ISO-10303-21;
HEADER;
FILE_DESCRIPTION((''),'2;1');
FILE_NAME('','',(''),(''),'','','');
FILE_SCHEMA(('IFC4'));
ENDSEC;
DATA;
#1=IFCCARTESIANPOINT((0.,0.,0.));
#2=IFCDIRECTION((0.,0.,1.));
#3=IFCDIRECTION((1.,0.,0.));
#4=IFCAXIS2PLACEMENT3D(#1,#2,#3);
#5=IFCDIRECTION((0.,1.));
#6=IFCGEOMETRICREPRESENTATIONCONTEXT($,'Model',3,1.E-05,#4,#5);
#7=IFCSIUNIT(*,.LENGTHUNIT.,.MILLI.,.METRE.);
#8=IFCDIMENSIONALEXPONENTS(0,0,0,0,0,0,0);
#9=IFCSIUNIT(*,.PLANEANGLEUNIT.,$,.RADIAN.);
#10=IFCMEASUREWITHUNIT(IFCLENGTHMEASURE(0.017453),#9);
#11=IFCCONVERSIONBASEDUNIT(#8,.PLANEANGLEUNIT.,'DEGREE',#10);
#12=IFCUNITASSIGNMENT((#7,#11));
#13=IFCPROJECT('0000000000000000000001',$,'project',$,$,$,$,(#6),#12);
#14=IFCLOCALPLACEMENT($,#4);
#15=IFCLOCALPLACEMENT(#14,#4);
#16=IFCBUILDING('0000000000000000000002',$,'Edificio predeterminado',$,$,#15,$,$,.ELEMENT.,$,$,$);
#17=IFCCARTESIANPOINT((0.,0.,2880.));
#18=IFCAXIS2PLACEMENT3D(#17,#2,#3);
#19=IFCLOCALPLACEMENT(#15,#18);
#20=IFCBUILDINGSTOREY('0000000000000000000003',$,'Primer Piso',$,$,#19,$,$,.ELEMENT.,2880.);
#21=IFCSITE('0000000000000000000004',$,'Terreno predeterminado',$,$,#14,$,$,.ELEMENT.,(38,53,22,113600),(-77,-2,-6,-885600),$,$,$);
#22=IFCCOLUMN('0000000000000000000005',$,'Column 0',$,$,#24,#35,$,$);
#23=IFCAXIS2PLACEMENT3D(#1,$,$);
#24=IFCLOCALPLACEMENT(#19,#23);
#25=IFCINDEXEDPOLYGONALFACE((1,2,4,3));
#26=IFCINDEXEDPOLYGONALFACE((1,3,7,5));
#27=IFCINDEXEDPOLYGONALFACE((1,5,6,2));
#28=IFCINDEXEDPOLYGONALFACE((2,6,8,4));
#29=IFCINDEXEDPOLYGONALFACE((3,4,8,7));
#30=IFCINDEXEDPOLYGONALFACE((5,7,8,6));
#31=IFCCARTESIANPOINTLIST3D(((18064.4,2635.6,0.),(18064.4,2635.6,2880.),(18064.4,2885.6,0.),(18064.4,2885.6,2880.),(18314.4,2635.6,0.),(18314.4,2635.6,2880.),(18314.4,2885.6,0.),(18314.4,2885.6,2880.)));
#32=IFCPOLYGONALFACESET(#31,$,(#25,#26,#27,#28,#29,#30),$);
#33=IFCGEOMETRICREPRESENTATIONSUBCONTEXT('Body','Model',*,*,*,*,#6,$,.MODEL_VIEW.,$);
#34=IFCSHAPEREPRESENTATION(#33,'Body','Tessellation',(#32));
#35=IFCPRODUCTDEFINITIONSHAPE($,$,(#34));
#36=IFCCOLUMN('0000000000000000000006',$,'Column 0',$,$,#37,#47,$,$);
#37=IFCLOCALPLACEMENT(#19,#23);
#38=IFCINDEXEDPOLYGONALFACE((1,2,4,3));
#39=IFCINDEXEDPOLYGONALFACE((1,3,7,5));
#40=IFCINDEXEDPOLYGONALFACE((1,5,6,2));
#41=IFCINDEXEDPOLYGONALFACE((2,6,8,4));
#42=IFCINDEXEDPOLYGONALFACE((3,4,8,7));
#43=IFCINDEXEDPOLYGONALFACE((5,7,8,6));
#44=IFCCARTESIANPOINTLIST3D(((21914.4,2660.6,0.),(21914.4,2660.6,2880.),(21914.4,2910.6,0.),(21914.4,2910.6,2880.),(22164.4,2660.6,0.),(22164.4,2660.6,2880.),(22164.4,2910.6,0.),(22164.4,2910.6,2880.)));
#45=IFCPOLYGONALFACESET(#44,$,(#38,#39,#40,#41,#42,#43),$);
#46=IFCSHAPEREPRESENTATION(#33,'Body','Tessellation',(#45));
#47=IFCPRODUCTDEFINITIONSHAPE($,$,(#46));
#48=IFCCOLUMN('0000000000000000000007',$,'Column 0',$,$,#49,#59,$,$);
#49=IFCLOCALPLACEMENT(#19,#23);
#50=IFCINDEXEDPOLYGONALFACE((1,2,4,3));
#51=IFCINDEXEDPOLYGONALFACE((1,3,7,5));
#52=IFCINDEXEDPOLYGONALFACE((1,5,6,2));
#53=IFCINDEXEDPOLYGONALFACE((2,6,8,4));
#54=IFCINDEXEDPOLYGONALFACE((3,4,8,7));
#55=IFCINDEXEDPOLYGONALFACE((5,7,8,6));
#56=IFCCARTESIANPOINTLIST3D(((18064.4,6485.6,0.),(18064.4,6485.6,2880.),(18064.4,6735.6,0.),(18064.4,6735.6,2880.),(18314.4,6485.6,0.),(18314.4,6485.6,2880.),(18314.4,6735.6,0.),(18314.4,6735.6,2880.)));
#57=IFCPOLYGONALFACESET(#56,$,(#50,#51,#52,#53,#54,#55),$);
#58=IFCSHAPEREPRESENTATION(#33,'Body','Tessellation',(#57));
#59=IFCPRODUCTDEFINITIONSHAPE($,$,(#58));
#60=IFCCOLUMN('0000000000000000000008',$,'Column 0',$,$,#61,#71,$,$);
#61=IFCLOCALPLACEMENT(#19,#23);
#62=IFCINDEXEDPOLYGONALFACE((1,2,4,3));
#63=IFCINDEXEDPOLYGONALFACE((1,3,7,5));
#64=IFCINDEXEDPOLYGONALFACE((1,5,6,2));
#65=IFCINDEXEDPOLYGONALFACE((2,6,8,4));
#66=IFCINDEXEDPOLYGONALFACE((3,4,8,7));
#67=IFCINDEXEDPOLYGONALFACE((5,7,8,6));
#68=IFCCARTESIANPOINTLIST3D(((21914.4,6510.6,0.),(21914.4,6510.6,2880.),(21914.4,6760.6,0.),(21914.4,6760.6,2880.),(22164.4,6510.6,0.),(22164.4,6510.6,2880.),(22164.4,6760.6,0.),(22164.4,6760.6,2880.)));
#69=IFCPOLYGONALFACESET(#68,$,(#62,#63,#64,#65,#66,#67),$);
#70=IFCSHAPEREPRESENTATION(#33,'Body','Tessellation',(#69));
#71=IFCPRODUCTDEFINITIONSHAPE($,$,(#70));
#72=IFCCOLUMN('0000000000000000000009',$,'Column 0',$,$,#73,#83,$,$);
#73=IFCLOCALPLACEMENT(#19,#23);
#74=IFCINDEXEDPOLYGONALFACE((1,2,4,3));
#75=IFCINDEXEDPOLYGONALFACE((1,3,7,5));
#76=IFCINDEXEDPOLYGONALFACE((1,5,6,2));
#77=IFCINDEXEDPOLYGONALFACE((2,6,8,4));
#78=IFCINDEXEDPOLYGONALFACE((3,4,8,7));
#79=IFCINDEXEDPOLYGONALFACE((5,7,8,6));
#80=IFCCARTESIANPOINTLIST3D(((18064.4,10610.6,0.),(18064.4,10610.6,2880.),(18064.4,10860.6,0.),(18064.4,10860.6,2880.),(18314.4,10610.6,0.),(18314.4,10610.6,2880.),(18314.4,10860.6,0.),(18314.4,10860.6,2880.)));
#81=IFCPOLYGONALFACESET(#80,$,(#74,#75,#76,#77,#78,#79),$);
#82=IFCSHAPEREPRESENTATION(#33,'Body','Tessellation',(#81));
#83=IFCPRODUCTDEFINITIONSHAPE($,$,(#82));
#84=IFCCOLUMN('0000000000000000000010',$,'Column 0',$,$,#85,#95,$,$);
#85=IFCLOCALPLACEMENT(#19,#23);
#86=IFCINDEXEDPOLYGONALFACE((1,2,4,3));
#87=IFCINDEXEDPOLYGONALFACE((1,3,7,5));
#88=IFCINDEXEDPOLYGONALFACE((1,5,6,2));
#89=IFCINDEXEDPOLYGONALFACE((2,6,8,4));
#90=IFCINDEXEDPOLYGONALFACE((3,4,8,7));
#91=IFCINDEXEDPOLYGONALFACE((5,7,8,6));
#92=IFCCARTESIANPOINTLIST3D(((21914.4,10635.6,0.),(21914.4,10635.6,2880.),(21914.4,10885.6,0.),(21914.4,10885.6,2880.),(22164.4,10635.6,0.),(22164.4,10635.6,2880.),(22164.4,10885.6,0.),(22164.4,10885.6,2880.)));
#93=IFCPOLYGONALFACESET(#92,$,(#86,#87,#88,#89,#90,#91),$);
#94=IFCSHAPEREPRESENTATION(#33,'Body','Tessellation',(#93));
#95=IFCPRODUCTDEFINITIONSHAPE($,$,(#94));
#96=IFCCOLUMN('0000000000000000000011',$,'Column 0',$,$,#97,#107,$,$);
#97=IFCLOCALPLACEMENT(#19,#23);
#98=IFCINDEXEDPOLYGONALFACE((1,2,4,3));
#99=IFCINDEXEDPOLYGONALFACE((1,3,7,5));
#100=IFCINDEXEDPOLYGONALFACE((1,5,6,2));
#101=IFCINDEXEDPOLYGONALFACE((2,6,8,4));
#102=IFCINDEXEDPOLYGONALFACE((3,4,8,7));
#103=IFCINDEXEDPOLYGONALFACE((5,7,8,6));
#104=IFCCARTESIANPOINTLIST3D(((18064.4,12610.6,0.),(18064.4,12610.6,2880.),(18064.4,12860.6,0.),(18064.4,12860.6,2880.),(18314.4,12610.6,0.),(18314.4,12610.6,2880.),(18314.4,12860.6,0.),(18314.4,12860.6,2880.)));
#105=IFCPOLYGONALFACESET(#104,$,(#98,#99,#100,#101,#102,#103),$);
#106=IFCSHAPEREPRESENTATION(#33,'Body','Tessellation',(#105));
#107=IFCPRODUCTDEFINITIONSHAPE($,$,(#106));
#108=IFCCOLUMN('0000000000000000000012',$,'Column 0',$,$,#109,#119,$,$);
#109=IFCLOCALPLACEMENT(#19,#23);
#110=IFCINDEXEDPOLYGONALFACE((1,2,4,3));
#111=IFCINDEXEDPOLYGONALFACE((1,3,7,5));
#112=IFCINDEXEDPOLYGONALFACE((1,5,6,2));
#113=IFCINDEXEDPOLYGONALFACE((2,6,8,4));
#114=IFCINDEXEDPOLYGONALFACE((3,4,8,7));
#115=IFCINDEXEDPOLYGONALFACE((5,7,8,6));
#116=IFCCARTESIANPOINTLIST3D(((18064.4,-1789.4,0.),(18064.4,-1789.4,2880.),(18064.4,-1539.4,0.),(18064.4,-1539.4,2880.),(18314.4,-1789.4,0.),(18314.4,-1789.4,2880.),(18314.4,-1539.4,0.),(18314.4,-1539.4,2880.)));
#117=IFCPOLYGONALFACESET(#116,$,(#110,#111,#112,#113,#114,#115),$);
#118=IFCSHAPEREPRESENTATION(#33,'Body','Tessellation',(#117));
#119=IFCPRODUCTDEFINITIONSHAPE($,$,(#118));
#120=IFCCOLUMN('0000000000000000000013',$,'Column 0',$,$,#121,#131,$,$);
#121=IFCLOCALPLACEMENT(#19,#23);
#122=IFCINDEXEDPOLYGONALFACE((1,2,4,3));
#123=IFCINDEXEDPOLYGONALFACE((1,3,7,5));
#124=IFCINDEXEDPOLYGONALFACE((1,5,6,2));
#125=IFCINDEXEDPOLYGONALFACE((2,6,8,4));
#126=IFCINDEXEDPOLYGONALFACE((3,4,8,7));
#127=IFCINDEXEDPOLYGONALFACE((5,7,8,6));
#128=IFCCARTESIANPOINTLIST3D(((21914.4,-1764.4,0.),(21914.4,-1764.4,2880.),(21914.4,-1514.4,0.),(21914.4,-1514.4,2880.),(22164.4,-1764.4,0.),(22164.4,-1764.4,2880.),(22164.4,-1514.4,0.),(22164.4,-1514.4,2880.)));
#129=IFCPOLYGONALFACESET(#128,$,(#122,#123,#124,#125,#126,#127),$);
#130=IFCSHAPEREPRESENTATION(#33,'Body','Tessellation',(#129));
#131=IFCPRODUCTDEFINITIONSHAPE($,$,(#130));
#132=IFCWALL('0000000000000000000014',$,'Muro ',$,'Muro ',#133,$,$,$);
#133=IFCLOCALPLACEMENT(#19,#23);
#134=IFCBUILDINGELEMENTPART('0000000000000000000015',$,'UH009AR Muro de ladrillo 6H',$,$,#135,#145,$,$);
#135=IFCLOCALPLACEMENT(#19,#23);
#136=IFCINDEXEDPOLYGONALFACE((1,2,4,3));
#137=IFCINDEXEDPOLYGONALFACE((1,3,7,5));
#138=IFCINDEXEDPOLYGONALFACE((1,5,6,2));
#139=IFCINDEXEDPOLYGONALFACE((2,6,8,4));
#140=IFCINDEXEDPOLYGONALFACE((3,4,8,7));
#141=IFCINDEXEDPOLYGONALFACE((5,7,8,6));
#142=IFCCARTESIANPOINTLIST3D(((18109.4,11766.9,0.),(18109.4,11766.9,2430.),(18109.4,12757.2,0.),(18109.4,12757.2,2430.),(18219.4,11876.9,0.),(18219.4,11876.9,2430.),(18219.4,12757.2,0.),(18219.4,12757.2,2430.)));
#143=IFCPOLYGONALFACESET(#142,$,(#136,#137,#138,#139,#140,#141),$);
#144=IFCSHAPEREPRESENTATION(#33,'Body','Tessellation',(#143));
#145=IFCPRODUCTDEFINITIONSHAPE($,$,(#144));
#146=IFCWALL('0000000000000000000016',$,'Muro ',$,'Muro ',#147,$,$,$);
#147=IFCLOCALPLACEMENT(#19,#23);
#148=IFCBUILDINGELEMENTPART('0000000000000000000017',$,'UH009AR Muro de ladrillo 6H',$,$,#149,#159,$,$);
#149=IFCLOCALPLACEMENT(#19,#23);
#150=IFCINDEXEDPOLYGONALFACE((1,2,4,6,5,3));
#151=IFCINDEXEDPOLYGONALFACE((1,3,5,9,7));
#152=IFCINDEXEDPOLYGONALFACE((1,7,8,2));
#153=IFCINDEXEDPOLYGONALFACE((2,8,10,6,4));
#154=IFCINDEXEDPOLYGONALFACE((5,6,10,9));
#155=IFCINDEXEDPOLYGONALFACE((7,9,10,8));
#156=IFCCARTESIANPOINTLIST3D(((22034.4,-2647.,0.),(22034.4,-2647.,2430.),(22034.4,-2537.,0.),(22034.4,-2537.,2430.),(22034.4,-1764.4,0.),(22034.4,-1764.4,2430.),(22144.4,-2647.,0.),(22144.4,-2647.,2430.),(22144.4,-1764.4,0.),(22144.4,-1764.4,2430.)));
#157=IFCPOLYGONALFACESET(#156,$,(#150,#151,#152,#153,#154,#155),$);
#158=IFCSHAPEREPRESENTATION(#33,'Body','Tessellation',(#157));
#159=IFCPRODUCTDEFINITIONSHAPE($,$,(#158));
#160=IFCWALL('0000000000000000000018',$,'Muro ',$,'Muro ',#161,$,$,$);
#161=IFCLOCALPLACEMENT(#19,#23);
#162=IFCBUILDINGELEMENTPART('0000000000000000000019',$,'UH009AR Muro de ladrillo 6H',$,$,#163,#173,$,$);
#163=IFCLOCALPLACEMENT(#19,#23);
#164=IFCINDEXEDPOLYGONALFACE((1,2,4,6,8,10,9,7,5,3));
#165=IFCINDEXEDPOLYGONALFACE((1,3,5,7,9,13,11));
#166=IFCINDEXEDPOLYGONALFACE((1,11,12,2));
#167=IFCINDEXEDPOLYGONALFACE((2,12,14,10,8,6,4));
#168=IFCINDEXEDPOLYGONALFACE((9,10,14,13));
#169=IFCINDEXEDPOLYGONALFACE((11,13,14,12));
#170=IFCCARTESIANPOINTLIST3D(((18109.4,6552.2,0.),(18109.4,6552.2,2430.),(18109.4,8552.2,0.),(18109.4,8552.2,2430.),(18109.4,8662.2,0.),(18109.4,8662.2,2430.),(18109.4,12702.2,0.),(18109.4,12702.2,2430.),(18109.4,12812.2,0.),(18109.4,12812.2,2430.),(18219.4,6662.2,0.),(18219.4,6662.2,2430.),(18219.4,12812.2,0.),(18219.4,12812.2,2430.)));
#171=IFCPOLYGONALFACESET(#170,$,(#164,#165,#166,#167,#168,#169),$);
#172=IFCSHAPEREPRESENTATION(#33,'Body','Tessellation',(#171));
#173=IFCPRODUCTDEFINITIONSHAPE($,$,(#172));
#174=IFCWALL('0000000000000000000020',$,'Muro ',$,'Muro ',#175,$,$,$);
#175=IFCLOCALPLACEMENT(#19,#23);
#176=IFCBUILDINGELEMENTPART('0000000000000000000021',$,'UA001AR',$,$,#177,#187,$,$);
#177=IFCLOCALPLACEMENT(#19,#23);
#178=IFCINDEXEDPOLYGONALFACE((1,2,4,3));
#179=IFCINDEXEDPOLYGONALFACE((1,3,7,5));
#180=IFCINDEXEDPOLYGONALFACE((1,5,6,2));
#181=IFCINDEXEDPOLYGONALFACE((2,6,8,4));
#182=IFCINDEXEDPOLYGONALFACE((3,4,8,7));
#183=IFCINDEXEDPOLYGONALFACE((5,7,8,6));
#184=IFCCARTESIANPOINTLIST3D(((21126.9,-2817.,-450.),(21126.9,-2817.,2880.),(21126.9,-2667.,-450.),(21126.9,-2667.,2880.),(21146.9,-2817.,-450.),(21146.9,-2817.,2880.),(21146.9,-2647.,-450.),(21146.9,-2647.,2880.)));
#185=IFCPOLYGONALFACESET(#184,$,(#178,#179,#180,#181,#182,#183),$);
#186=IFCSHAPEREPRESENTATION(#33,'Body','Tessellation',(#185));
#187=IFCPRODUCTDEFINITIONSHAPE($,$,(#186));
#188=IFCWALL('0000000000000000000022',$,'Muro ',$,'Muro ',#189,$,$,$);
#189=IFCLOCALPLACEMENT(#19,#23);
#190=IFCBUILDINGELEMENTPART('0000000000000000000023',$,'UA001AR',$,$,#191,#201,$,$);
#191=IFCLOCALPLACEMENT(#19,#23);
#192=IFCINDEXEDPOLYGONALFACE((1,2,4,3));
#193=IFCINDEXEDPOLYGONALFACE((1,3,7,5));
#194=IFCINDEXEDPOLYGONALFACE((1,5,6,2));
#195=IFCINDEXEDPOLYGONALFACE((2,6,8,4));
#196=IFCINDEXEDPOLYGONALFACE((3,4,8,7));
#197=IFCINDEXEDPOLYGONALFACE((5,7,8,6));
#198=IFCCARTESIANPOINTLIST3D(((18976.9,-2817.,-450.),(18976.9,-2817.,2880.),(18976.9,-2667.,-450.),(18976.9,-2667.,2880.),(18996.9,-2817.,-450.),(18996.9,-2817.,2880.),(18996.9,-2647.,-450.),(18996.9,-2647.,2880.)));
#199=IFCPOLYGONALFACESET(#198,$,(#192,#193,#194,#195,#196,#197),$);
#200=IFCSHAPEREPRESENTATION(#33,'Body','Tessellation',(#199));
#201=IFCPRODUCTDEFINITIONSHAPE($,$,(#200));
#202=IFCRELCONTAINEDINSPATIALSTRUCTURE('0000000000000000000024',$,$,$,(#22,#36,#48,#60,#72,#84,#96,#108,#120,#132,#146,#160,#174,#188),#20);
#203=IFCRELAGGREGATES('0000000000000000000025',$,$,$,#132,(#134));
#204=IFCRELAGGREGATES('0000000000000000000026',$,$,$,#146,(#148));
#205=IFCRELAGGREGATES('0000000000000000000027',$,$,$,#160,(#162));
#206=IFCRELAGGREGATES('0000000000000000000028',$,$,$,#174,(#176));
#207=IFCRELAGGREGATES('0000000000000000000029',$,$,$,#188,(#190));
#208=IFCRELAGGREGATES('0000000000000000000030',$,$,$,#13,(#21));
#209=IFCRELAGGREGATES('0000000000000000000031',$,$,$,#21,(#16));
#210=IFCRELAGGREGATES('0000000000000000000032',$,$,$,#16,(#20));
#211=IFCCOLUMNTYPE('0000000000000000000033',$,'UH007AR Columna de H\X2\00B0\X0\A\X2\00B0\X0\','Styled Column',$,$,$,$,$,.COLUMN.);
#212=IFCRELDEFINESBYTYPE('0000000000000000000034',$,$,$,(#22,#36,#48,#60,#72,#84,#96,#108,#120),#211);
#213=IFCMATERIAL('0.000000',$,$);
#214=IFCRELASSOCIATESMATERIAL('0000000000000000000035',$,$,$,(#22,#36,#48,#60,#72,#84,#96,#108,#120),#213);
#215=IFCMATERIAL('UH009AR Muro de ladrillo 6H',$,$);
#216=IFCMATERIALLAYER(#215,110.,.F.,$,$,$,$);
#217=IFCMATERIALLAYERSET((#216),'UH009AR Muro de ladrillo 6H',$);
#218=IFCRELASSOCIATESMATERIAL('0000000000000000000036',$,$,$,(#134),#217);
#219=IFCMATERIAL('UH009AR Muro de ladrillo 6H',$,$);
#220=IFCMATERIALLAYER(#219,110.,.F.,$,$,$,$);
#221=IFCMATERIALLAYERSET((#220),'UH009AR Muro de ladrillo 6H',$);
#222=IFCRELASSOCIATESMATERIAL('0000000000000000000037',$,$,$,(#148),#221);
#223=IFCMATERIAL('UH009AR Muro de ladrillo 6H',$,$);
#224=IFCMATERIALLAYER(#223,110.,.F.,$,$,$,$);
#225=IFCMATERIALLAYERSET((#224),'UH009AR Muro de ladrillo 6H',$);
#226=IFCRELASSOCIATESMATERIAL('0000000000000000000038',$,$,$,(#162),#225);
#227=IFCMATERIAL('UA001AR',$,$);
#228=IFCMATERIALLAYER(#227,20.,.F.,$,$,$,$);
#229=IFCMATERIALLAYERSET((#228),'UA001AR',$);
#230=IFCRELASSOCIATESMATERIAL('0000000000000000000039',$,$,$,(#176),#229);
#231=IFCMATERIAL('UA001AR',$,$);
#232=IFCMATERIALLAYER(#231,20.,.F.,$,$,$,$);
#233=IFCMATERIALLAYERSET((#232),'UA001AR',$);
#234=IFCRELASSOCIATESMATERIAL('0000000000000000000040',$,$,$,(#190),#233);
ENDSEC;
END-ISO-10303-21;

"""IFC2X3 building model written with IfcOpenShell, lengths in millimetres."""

from ifc_helpers import new_model, entity, si_unit, converted_unit, direction, frame, origin_with_axes, place, context, subcontext, project, spatial, polyline, outline, extrude, clip, bounded_halfspace, material, layer, layer_set, layer_usage, type_object, element, aggregate, save


model = new_model("IFC2X3")

# Units and contexts
model_context = context("Model", 3, precision=1e-05, world=origin_with_axes(), true_north=direction((0.0, 1.0)))
body_context = subcontext(model_context, "Body", "Model", "MODEL_VIEW")
ifc_project = project(units=[si_unit("LENGTHUNIT", "METRE", prefix="MILLI"), converted_unit("PLANEANGLEUNIT", "DEGREE", entity("IfcLengthMeasure", 0.017453), si_unit("PLANEANGLEUNIT", "RADIAN"), dimensions=[0, 0, 0, 0, 0, 0, 0])], contexts=[model_context])

# Site, building, storey
site_placement = place(None, origin_with_axes())
site = spatial("IfcSite", under=ifc_project, at=site_placement, Name="Terreno predeterminado", CompositionType="ELEMENT", RefLatitude=(38, 53, 22, 113600), RefLongitude=(-77, -2, -6, -885600))
building_placement = place(site_placement, origin_with_axes())
building = spatial("IfcBuilding", under=site, at=building_placement, Name="Edificio predeterminado", CompositionType="ELEMENT")
storey_placement = place(building_placement, frame((0.0, 0.0, 2880.0), z_axis=(0.0, 0.0, 1.0), x_axis=(1.0, 0.0, 0.0)))
storey = spatial("IfcBuildingStorey", under=building, at=storey_placement, Name="Primer Piso", CompositionType="ELEMENT", Elevation=2880.0)

# Columns
ifc_material_1 = material(Name="0.000000")
column_type = type_object("IfcColumnType", Name="UH007AR Columna de H°A°", Description="Styled Column", PredefinedType="COLUMN")
for number, where, z_axis, x_axis, name in (
    (1, (18189.4, 2760.6, 0.0), (0.0, 0.0, 1.0), (1.0, 0.0, 0.0), "Column 0"),
    (2, (22039.4, 2785.6, 0.0), (0.0, 0.0, 1.0), (1.0, 0.0, 0.0), "Column 0"),
    (3, (18189.4, 6610.6, 0.0), (0.0, 0.0, 1.0), (1.0, 0.0, 0.0), "Column 0"),
    (4, (22039.4, 6635.6, 0.0), (0.0, 0.0, 1.0), (1.0, 0.0, 0.0), "Column 0"),
    (5, (18189.4, 10735.6, 0.0), (0.0, 0.0, 1.0), (1.0, 0.0, 0.0), "Column 0"),
    (6, (22039.4, 10760.6, 0.0), (0.0, 0.0, 1.0), (1.0, 0.0, 0.0), "Column 0"),
    (7, (18189.4, 12735.6, 0.0), (0.0, 0.0, 1.0), (1.0, 0.0, 0.0), "Column 0"),
    (8, (18189.4, -1664.4, 0.0), (0.0, 0.0, 1.0), (1.0, 0.0, 0.0), "Column 0"),
    (9, (22039.4, -1639.4, 0.0), (0.0, 0.0, 1.0), (1.0, 0.0, 0.0), "Column 0"),
):
    element("IfcColumn", number, at=place(storey_placement, frame(where, z_axis=z_axis, x_axis=x_axis)), inside=storey, type_object=column_type, material=ifc_material_1, Name=name, context=body_context, shape_type="SweptSolid", body=[
        extrude(outline(polyline([(-125.0, -125.0), (125.0, -125.0), (125.0, 125.0), (-125.0, 125.0), (-125.0, -125.0)])), origin_with_axes(), (0.0, 0.0, 1.0), 2880.0),
    ])

# Walls, building element parts
wall_1_placement = place(storey_placement, frame((18164.4, 11821.9, 0.0), z_axis=(0.0, 0.0, 1.0), x_axis=(0.0, 1.0, 0.0)))
wall_1 = element("IfcWall", 10, at=wall_1_placement, inside=storey, Name="Muro ", ObjectType="Muro ")
ifc_material_2 = material(Name="UH009AR Muro de ladrillo 6H")
ifc_layer_1 = layer(ifc_material_2, 110.0, ventilated=False)
ifc_layer_set_1 = layer_set([ifc_layer_1], Name="UH009AR Muro de ladrillo 6H")
ifc_layer_usage_1 = layer_usage(ifc_layer_set_1, "AXIS2", "NEGATIVE", -55.0)
building_element_part_1_placement = place(wall_1_placement, origin_with_axes())
building_element_part_1 = element("IfcBuildingElementPart", 11, at=building_element_part_1_placement, material=ifc_layer_usage_1, Name="UH009AR Muro de ladrillo 6H", context=body_context, shape_type="SweptSolid", body=[
    extrude(outline(polyline([(935.2, 55.0), (935.2, -55.0), (55.0, -55.0), (-55.0, 55.0), (935.2, 55.0)])), origin_with_axes(), (0.0, 0.0, 1.0), 2430.0),
])
aggregate(wall_1, [building_element_part_1])
wall_2_placement = place(storey_placement, frame((22089.4, -1764.4, 0.0), z_axis=(0.0, 0.0, 1.0), x_axis=(0.0, -1.0, 0.0)))
wall_2 = element("IfcWall", 12, at=wall_2_placement, inside=storey, Name="Muro ", ObjectType="Muro ")
ifc_material_3 = material(Name="UH009AR Muro de ladrillo 6H")
ifc_layer_2 = layer(ifc_material_3, 110.0, ventilated=False)
ifc_layer_set_2 = layer_set([ifc_layer_2], Name="UH009AR Muro de ladrillo 6H")
ifc_layer_usage_2 = layer_usage(ifc_layer_set_2, "AXIS2", "NEGATIVE", -55.0)
building_element_part_2_placement = place(wall_2_placement, origin_with_axes())
building_element_part_2 = element("IfcBuildingElementPart", 13, at=building_element_part_2_placement, material=ifc_layer_usage_2, Name="UH009AR Muro de ladrillo 6H", context=body_context, shape_type="SweptSolid", body=[
    extrude(outline(polyline([(882.6, 55.0), (882.6, -55.0), (772.6, -55.0), (0.0, -55.0), (0.0, 55.0), (882.6, 55.0)])), origin_with_axes(), (0.0, 0.0, 1.0), 2430.0),
])
aggregate(wall_2, [building_element_part_2])
wall_3_placement = place(storey_placement, frame((18164.4, 12757.2, 0.0), z_axis=(0.0, 0.0, 1.0), x_axis=(0.0, -1.0, 0.0)))
wall_3 = element("IfcWall", 14, at=wall_3_placement, inside=storey, Name="Muro ", ObjectType="Muro ")
ifc_material_4 = material(Name="UH009AR Muro de ladrillo 6H")
ifc_layer_3 = layer(ifc_material_4, 110.0, ventilated=False)
ifc_layer_set_3 = layer_set([ifc_layer_3], Name="UH009AR Muro de ladrillo 6H")
ifc_layer_usage_3 = layer_usage(ifc_layer_set_3, "AXIS2", "NEGATIVE", -55.0)
building_element_part_3_placement = place(wall_3_placement, origin_with_axes())
building_element_part_3 = element("IfcBuildingElementPart", 15, at=building_element_part_3_placement, material=ifc_layer_usage_3, Name="UH009AR Muro de ladrillo 6H", context=body_context, shape_type="SweptSolid", body=[
    extrude(outline(polyline([(6095.0, 55.0), (6205.0, -55.0), (4205.0, -55.0), (4095.0, -55.0), (55.0, -55.0), (-55.0, -55.0), (-55.0, 55.0), (6095.0, 55.0)])), origin_with_axes(), (0.0, 0.0, 1.0), 2430.0),
])
aggregate(wall_3, [building_element_part_3])
wall_4_placement = place(storey_placement, frame((21201.9, -2817.0, 0.0), z_axis=(0.0, 0.0, 1.0), x_axis=(0.0, 1.0, 0.0)))
wall_4 = element("IfcWall", 16, at=wall_4_placement, inside=storey, Name="Muro ", ObjectType="Muro ")
ifc_material_5 = material(Name="UA001AR")
ifc_layer_4 = layer(ifc_material_5, 20.0, ventilated=False)
ifc_layer_set_4 = layer_set([ifc_layer_4], Name="UA001AR")
ifc_layer_usage_4 = layer_usage(ifc_layer_set_4, "AXIS2", "NEGATIVE", -75.0)
building_element_part_4_placement = place(wall_4_placement, origin_with_axes())
building_element_part_4 = element("IfcBuildingElementPart", 17, at=building_element_part_4_placement, material=ifc_layer_usage_4, Name="UA001AR", context=body_context, shape_type="Clipping", body=[
    clip(clip(extrude(outline(polyline([(150.0, 75.0), (170.0, 55.0), (0.0, 55.0), (0.0, 75.0), (150.0, 75.0)])), frame((0.0, 0.0, -450.0), z_axis=(0.0, 0.0, 1.0), x_axis=(1.0, 0.0, 0.0)), (0.0, 0.0, 1.0), 3330.0), bounded_halfspace(frame((0.0, 0.0, -450.0), z_axis=(0.0, 0.0, 1.0), x_axis=(1.0, 0.0, 0.0)), True, origin_with_axes(), polyline([(-150.0, -150.0), (375.0, -150.0), (375.0, 150.0), (-150.0, 150.0), (-150.0, -150.0)]))), bounded_halfspace(frame((0.0, 0.0, 2880.0), z_axis=(0.0, 0.0, 1.0), x_axis=(1.0, 0.0, 0.0)), False, origin_with_axes(), polyline([(-150.0, -150.0), (375.0, -150.0), (375.0, 150.0), (-150.0, 150.0), (-150.0, -150.0)]))),
])
aggregate(wall_4, [building_element_part_4])
wall_5_placement = place(storey_placement, frame((19051.9, -2817.0, 0.0), z_axis=(0.0, 0.0, 1.0), x_axis=(0.0, 1.0, 0.0)))
wall_5 = element("IfcWall", 18, at=wall_5_placement, inside=storey, Name="Muro ", ObjectType="Muro ")
ifc_material_6 = material(Name="UA001AR")
ifc_layer_5 = layer(ifc_material_6, 20.0, ventilated=False)
ifc_layer_set_5 = layer_set([ifc_layer_5], Name="UA001AR")
ifc_layer_usage_5 = layer_usage(ifc_layer_set_5, "AXIS2", "NEGATIVE", -75.0)
building_element_part_5_placement = place(wall_5_placement, origin_with_axes())
building_element_part_5 = element("IfcBuildingElementPart", 19, at=building_element_part_5_placement, material=ifc_layer_usage_5, Name="UA001AR", context=body_context, shape_type="Clipping", body=[
    clip(clip(extrude(outline(polyline([(150.0, 75.0), (170.0, 55.0), (0.0, 55.0), (0.0, 75.0), (150.0, 75.0)])), frame((0.0, 0.0, -450.0), z_axis=(0.0, 0.0, 1.0), x_axis=(1.0, 0.0, 0.0)), (0.0, 0.0, 1.0), 3330.0), bounded_halfspace(frame((0.0, 0.0, -450.0), z_axis=(0.0, 0.0, 1.0), x_axis=(1.0, 0.0, 0.0)), True, origin_with_axes(), polyline([(-150.0, -150.0), (375.0, -150.0), (375.0, 150.0), (-150.0, 150.0), (-150.0, -150.0)]))), bounded_halfspace(frame((0.0, 0.0, 2880.0), z_axis=(0.0, 0.0, 1.0), x_axis=(1.0, 0.0, 0.0)), False, origin_with_axes(), polyline([(-150.0, -150.0), (375.0, -150.0), (375.0, 150.0), (-150.0, 150.0), (-150.0, -150.0)]))),
])
aggregate(wall_5, [building_element_part_5])

save(model, "model.ifc")
